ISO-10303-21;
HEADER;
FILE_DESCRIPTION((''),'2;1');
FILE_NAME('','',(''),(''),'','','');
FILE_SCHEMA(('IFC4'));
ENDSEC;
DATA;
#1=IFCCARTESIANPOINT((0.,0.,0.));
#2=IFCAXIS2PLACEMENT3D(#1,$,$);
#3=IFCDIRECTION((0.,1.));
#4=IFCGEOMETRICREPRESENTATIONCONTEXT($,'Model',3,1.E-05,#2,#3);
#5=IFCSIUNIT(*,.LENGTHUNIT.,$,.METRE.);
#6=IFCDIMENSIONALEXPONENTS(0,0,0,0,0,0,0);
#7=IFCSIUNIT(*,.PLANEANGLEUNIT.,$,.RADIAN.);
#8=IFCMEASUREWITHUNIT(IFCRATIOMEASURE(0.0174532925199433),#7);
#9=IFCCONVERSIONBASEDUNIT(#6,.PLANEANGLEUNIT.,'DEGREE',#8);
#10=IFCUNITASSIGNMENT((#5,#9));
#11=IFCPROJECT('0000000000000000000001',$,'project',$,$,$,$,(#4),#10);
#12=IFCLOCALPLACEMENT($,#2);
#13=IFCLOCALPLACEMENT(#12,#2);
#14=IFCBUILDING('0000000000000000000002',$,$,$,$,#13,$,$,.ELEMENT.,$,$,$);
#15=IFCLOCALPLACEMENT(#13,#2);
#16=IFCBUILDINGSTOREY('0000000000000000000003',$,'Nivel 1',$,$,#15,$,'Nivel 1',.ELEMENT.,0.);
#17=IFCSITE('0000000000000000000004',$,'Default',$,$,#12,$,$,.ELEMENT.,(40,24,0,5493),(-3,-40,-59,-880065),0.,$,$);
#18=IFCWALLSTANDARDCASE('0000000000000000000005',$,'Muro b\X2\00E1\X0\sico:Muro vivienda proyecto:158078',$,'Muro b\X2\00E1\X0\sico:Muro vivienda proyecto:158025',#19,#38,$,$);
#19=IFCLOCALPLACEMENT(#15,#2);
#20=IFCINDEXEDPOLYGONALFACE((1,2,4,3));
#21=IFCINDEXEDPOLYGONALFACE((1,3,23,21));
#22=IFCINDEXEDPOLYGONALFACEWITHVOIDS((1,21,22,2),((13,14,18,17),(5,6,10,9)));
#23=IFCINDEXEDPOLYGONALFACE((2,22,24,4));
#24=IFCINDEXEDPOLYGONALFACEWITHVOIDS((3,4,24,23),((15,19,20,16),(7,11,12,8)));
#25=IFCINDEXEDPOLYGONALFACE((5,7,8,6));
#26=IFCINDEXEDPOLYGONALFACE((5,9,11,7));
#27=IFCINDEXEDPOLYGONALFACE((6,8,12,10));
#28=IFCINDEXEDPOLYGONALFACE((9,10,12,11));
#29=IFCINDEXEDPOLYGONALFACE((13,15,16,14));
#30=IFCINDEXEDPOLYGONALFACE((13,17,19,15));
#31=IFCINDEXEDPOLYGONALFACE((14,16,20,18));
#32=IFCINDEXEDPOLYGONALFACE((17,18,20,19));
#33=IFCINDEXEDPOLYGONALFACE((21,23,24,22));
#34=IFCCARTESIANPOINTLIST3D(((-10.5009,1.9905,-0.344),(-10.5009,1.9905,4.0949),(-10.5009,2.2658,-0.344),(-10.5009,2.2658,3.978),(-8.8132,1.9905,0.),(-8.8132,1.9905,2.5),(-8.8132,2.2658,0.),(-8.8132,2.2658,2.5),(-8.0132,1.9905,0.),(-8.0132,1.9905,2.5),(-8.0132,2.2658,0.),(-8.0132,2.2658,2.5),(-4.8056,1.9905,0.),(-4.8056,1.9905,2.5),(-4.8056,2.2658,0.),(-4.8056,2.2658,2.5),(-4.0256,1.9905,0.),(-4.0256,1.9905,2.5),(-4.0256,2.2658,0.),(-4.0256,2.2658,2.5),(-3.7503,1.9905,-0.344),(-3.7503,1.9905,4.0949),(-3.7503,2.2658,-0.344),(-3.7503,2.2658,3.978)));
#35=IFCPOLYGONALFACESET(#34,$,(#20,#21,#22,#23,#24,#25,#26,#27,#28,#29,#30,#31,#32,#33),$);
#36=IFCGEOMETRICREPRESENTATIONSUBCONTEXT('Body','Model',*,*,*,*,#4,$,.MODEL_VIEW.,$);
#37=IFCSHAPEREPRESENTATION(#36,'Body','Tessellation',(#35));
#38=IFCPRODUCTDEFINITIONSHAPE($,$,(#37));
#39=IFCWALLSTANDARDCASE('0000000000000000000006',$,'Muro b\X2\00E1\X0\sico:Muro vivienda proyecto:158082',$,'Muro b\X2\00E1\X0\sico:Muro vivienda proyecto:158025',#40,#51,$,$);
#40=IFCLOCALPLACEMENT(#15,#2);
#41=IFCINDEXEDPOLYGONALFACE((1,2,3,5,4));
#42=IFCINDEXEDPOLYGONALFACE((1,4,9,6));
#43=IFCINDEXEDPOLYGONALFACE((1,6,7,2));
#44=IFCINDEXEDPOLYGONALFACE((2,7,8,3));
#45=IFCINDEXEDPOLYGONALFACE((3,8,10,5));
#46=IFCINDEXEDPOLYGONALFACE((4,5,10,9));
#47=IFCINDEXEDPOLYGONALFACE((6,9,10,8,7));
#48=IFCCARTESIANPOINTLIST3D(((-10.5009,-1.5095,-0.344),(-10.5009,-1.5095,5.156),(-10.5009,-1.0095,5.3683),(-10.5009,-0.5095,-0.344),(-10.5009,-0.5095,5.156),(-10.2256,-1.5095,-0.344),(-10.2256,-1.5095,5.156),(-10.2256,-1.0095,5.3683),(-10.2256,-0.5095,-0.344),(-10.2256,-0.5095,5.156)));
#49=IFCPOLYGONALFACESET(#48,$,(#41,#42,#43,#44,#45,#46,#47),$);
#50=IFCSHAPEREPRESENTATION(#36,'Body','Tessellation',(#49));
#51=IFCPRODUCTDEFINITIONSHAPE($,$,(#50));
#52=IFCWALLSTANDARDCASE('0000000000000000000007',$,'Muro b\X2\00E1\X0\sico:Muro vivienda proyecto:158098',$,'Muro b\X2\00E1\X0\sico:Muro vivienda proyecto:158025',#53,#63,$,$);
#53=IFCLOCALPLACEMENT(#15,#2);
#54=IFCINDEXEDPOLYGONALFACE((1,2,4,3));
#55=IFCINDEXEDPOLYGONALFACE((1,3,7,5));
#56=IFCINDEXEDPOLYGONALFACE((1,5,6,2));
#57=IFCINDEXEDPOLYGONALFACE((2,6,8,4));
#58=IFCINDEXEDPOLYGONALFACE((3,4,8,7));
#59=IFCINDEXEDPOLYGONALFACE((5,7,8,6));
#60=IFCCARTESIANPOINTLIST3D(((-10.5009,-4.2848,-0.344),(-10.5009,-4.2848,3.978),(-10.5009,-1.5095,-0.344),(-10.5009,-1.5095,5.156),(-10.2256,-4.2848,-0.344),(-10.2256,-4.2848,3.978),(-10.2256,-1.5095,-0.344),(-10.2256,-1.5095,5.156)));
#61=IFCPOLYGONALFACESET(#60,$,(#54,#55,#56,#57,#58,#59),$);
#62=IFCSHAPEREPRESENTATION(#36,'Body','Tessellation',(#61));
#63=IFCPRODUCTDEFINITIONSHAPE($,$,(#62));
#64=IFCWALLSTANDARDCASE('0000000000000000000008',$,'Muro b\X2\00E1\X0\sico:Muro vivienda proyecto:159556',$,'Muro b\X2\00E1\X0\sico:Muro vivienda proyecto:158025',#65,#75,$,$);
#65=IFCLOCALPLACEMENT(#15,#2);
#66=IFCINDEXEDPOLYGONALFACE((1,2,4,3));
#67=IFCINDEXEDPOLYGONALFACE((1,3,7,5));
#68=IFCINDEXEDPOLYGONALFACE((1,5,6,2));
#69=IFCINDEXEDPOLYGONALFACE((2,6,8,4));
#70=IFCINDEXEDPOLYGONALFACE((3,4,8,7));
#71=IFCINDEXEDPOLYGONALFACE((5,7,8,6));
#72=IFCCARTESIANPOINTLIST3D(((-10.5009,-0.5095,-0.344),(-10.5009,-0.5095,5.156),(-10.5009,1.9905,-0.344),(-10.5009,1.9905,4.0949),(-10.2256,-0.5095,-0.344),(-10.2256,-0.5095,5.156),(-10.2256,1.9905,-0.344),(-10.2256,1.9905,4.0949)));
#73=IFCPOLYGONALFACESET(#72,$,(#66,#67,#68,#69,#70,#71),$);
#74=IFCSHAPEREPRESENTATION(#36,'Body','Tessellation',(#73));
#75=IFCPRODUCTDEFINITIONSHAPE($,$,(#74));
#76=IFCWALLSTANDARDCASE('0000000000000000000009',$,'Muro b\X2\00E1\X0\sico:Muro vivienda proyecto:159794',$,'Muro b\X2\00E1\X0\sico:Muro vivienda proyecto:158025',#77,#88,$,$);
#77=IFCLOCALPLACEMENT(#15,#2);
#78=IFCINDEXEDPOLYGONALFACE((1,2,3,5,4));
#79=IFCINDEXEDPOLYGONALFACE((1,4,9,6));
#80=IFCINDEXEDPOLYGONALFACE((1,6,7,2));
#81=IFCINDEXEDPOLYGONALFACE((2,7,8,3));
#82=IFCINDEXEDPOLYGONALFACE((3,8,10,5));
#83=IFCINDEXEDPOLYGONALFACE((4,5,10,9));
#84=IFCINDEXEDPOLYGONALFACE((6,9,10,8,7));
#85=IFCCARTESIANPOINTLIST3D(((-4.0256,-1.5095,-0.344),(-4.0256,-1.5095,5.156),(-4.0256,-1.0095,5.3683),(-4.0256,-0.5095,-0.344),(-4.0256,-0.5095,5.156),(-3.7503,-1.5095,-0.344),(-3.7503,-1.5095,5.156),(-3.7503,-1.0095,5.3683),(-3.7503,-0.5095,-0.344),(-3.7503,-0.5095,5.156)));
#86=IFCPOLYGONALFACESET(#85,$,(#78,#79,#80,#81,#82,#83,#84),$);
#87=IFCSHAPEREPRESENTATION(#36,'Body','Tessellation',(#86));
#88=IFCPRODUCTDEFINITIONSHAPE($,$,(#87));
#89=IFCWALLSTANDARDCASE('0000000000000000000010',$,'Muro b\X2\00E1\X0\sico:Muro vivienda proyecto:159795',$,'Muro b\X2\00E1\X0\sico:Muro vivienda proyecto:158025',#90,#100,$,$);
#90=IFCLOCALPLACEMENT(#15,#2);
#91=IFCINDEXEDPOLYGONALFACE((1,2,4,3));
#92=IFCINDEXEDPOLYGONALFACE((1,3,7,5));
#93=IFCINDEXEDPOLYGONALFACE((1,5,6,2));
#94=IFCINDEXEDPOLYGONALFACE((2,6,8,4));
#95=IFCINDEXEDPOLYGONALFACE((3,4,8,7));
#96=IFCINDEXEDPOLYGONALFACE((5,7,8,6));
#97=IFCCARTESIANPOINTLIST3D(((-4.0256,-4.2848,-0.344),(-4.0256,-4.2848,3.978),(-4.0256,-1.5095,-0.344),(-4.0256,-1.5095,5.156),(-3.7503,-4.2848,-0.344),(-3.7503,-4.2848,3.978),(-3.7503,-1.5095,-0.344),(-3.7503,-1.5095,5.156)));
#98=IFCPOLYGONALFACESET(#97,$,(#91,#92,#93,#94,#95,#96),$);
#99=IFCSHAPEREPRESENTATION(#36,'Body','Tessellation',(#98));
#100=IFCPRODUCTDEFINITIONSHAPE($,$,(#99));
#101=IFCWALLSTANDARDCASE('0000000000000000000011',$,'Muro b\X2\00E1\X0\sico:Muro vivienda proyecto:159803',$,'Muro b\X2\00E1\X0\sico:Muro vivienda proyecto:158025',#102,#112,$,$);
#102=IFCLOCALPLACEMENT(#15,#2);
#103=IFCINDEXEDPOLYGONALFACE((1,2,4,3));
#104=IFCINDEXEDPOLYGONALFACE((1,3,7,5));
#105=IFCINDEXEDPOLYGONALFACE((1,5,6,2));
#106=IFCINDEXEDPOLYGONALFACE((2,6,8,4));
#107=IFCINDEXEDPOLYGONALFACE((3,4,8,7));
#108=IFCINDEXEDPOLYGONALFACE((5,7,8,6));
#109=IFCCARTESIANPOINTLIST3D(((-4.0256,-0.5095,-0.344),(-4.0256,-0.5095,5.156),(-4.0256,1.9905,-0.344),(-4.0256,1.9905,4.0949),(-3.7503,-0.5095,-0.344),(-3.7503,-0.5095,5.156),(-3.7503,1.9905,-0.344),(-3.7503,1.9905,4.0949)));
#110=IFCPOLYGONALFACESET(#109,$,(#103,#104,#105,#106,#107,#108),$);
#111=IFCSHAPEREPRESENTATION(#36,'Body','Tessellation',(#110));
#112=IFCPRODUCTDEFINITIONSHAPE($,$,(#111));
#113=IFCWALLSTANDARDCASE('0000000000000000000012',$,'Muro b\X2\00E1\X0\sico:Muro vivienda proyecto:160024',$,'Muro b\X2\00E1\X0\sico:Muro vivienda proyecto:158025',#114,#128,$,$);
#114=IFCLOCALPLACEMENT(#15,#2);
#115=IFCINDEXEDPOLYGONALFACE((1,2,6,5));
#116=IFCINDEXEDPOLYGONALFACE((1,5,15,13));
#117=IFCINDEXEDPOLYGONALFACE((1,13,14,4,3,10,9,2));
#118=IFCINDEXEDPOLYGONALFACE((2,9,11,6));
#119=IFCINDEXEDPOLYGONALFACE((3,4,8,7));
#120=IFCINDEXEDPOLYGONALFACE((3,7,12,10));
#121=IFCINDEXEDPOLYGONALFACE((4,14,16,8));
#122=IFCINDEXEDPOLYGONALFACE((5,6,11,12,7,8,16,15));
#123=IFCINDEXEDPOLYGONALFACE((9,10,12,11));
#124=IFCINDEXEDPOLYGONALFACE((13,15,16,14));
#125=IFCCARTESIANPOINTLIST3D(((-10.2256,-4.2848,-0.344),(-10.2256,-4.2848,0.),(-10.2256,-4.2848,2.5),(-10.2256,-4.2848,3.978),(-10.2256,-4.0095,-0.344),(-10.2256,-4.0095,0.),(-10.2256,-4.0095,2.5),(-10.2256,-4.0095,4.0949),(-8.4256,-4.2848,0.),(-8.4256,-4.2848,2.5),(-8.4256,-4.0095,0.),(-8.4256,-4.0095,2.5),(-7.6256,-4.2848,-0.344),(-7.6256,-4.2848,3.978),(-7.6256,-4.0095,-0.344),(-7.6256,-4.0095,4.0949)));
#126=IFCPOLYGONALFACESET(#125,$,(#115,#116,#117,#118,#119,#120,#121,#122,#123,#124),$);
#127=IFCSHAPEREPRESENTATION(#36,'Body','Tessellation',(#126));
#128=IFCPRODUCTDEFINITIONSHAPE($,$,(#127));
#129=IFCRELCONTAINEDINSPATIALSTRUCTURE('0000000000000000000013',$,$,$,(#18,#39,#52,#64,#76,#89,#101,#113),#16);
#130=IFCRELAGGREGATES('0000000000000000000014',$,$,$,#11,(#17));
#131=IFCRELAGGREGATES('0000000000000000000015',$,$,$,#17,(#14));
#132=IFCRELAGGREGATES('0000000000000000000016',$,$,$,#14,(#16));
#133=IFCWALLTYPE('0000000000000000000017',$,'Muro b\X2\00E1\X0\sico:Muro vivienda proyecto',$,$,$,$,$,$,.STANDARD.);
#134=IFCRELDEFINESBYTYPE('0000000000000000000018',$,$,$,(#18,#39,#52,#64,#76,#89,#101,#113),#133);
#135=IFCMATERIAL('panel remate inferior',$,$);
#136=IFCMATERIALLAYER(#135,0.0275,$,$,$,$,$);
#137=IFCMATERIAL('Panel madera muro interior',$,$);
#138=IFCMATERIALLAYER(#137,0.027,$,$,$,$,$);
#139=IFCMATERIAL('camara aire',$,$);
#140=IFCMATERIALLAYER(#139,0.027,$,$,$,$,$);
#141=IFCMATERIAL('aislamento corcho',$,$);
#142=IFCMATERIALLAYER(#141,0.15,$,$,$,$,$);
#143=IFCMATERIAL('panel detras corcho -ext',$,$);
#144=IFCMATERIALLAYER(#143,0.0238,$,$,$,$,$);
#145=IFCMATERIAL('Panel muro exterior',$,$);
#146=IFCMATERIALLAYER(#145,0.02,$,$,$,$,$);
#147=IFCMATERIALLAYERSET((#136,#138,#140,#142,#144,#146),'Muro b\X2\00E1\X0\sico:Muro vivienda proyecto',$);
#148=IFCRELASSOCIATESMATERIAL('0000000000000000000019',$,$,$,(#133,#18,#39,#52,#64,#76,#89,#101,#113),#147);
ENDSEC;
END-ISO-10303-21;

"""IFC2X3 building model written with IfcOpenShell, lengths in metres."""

from ifc_helpers import new_model, entity, si_unit, converted_unit, direction, frame, frame_2d, origin, place, context, subcontext, project, spatial, polyline, rectangle, extrude, clip, bounded_halfspace, material, layer, layer_set, layer_usage, type_object, element, save


model = new_model("IFC2X3")

# Units and contexts
model_context = context("Model", 3, precision=1e-05, world=origin(), true_north=direction((0.0, 1.0)))
body_context = subcontext(model_context, "Body", "Model", "MODEL_VIEW")
ifc_project = project(units=[si_unit("LENGTHUNIT", "METRE"), converted_unit("PLANEANGLEUNIT", "DEGREE", entity("IfcRatioMeasure", 0.0174532925199433), si_unit("PLANEANGLEUNIT", "RADIAN"), dimensions=[0, 0, 0, 0, 0, 0, 0])], contexts=[model_context])

# Site, building, storey
site_placement = place(None, origin())
site = spatial("IfcSite", under=ifc_project, at=site_placement, Name="Default", CompositionType="ELEMENT", RefLatitude=(40, 24, 0, 5493), RefLongitude=(-3, -40, -59, -880065), RefElevation=0.0)
building_placement = place(site_placement, origin())
building = spatial("IfcBuilding", under=site, at=building_placement, CompositionType="ELEMENT")
storey_placement = place(building_placement, origin())
storey = spatial("IfcBuildingStorey", under=building, at=storey_placement, Name="Nivel 1", LongName="Nivel 1", CompositionType="ELEMENT", Elevation=0.0)

# Shared definitions
ifc_material_1 = material(Name="aislamento corcho")
ifc_material_2 = material(Name="camara aire")
ifc_material_3 = material(Name="panel remate inferior")

# Shared definitions
ifc_layer_1 = layer(ifc_material_3, 0.0275)
ifc_material_4 = material(Name="Panel madera muro interior")
ifc_layer_2 = layer(ifc_material_4, 0.027)
ifc_layer_3 = layer(ifc_material_2, 0.027)
ifc_layer_4 = layer(ifc_material_1, 0.15)
ifc_material_5 = material(Name="panel detras corcho -ext")
ifc_layer_5 = layer(ifc_material_5, 0.0238)
ifc_material_6 = material(Name="Panel muro exterior")
ifc_layer_6 = layer(ifc_material_6, 0.02)
ifc_layer_set_1 = layer_set([ifc_layer_1, ifc_layer_2, ifc_layer_3, ifc_layer_4, ifc_layer_5, ifc_layer_6], Name="Muro básico:Muro vivienda proyecto")
wall_type = type_object("IfcWallType", Name="Muro básico:Muro vivienda proyecto", PredefinedType="STANDARD", material=ifc_layer_set_1)

# Wall, openings
ifc_layer_usage_1 = layer_usage(ifc_layer_set_1, "AXIS2", "NEGATIVE", 0.1376)
wall_1_placement = place(storey_placement, frame((-10.5009, 2.1282, -0.344)))
wall_1 = element("IfcWallStandardCase", 1, at=wall_1_placement, inside=storey, type_object=wall_type, material=ifc_layer_usage_1, Name="Muro básico:Muro vivienda proyecto:158078", ObjectType="Muro básico:Muro vivienda proyecto:158025", context=body_context, shape_type="Clipping", body=[
    clip(extrude(rectangle(XDim=6.7506, YDim=0.2753, at=frame_2d((3.3753, 0.0), x_axis=(-1.0, 0.0))), origin(), (0.0, 0.0, 1.0), 4.4389), bounded_halfspace(frame((0.0, -0.1376, 4.4389), z_axis=(0.0, 0.390731, 0.920505), x_axis=(-1.0, 0.0, 0.0)), False, frame((0.0, -0.1376, 4.4389)), polyline([(0.0, 0.0), (0.2753, 0.0), (6.4753, 0.0), (6.7506, 0.0), (6.7506, 0.2753), (0.0, 0.2753), (0.0, 0.0)]))),
])
opening_1_placement = place(wall_1_placement, origin())
element("IfcOpeningElement", 2, at=opening_1_placement, cuts=wall_1, ObjectType="Opening", context=body_context, shape_type="SweptSolid", body=[
    extrude(rectangle(XDim=2.5, YDim=0.8, at=frame_2d((0.0, 0.0), x_axis=(0.0, 1.0))), frame((2.0876, -0.29, 1.594), z_axis=(0.0, 1.0, 0.0), x_axis=(-1.0, 0.0, 0.0)), (0.0, 0.0, 1.0), 0.5801),
])
opening_2_placement = place(wall_1_placement, origin())
element("IfcOpeningElement", 3, at=opening_2_placement, cuts=wall_1, ObjectType="Opening", context=body_context, shape_type="SweptSolid", body=[
    extrude(rectangle(XDim=2.5, YDim=0.78, at=frame_2d((0.0, 0.0), x_axis=(0.0, 1.0))), frame((6.0853, -0.29, 1.594), z_axis=(0.0, 1.0, 0.0), x_axis=(-1.0, 0.0, 0.0)), (0.0, 0.0, 1.0), 0.5801),
])

# Walls
ifc_layer_usage_2 = layer_usage(ifc_layer_set_1, "AXIS2", "NEGATIVE", 0.1376)
wall_2_placement = place(storey_placement, frame((-10.3632, -1.5095, -0.344), z_axis=(0.0, 0.0, 1.0), x_axis=(0.0, 1.0, 0.0)))
element("IfcWallStandardCase", 4, at=wall_2_placement, inside=storey, type_object=wall_type, material=ifc_layer_usage_2, Name="Muro básico:Muro vivienda proyecto:158082", ObjectType="Muro básico:Muro vivienda proyecto:158025", context=body_context, shape_type="Clipping", body=[
    clip(clip(extrude(rectangle(XDim=1.0, YDim=0.2753, at=frame_2d((0.5, 0.0), x_axis=(-1.0, 0.0))), origin(), (0.0, 0.0, 1.0), 5.7123), bounded_halfspace(frame((0.5, -0.1377, 5.7123), z_axis=(0.390731, 0.0, 0.920505), x_axis=(0.0, 1.0, 0.0)), False, frame((0.5, -0.1377, 5.7123)), polyline([(0.0, 0.0), (0.5, 0.0), (0.5, 0.2753), (0.0, 0.2753), (0.0, 0.0)]))), bounded_halfspace(frame((0.0, -0.1377, 5.5), z_axis=(-0.390731, 0.0, 0.920505), x_axis=(0.0, -1.0, 0.0)), False, frame((0.0, -0.1377, 5.5)), polyline([(0.0, 0.0), (0.5, 0.0), (0.5, 0.2753), (0.0, 0.2753), (0.0, 0.0)]))),
])
ifc_layer_usage_3 = layer_usage(ifc_layer_set_1, "AXIS2", "NEGATIVE", 0.1376)
wall_3_placement = place(storey_placement, frame((-10.3632, -4.2848, -0.344), z_axis=(0.0, 0.0, 1.0), x_axis=(0.0, 1.0, 0.0)))
element("IfcWallStandardCase", 5, at=wall_3_placement, inside=storey, type_object=wall_type, material=ifc_layer_usage_3, Name="Muro básico:Muro vivienda proyecto:158098", ObjectType="Muro básico:Muro vivienda proyecto:158025", context=body_context, shape_type="Clipping", body=[
    clip(extrude(rectangle(XDim=2.7753, YDim=0.2753, at=frame_2d((1.3877, 0.0), x_axis=(-1.0, 0.0))), origin(), (0.0, 0.0, 1.0), 5.5), bounded_halfspace(frame((0.0, -0.1377, 4.322), z_axis=(-0.390731, 0.0, 0.920505), x_axis=(0.0, -1.0, 0.0)), False, frame((0.0, -0.1377, 4.322)), polyline([(0.0, 0.0), (0.2753, 0.0), (2.7753, 0.0), (2.7753, 0.2753), (0.0, 0.2753), (0.0, 0.0)]))),
])
ifc_layer_usage_4 = layer_usage(ifc_layer_set_1, "AXIS2", "POSITIVE", -0.1376)
wall_4_placement = place(storey_placement, frame((-10.3632, 1.9905, -0.344), z_axis=(0.0, 0.0, 1.0), x_axis=(0.0, -1.0, 0.0)))
element("IfcWallStandardCase", 6, at=wall_4_placement, inside=storey, type_object=wall_type, material=ifc_layer_usage_4, Name="Muro básico:Muro vivienda proyecto:159556", ObjectType="Muro básico:Muro vivienda proyecto:158025", context=body_context, shape_type="Clipping", body=[
    clip(extrude(rectangle(XDim=2.5, YDim=0.2753, at=frame_2d((1.25, 0.0), x_axis=(-1.0, 0.0))), origin(), (0.0, 0.0, 1.0), 5.5), bounded_halfspace(frame((0.0, -0.1377, 4.4389), z_axis=(-0.390731, 0.0, 0.920505), x_axis=(0.0, -1.0, 0.0)), False, frame((0.0, -0.1377, 4.4389)), polyline([(0.0, 0.0), (2.5, 0.0), (2.5, 0.2753), (0.0, 0.2753), (0.0, 0.0)]))),
])
ifc_layer_usage_5 = layer_usage(ifc_layer_set_1, "AXIS2", "POSITIVE", -0.1376)
wall_5_placement = place(storey_placement, frame((-3.8879, -1.5095, -0.344), z_axis=(0.0, 0.0, 1.0), x_axis=(0.0, 1.0, 0.0)))
element("IfcWallStandardCase", 7, at=wall_5_placement, inside=storey, type_object=wall_type, material=ifc_layer_usage_5, Name="Muro básico:Muro vivienda proyecto:159794", ObjectType="Muro básico:Muro vivienda proyecto:158025", context=body_context, shape_type="Clipping", body=[
    clip(clip(extrude(rectangle(XDim=1.0, YDim=0.2753, at=frame_2d((0.5, 0.0), x_axis=(-1.0, 0.0))), origin(), (0.0, 0.0, 1.0), 5.7123), bounded_halfspace(frame((0.5, -0.1376, 5.7123), z_axis=(0.390731, 0.0, 0.920505), x_axis=(0.0, 1.0, 0.0)), False, frame((0.5, -0.1376, 5.7123)), polyline([(0.0, 0.0), (0.5, 0.0), (0.5, 0.2753), (0.0, 0.2753), (0.0, 0.0)]))), bounded_halfspace(frame((0.0, -0.1376, 5.5), z_axis=(-0.390731, 0.0, 0.920505), x_axis=(0.0, -1.0, 0.0)), False, frame((0.0, -0.1376, 5.5)), polyline([(0.0, 0.0), (0.5, 0.0), (0.5, 0.2753), (0.0, 0.2753), (0.0, 0.0)]))),
])
ifc_layer_usage_6 = layer_usage(ifc_layer_set_1, "AXIS2", "POSITIVE", -0.1376)
wall_6_placement = place(storey_placement, frame((-3.8879, -4.2848, -0.344), z_axis=(0.0, 0.0, 1.0), x_axis=(0.0, 1.0, 0.0)))
element("IfcWallStandardCase", 8, at=wall_6_placement, inside=storey, type_object=wall_type, material=ifc_layer_usage_6, Name="Muro básico:Muro vivienda proyecto:159795", ObjectType="Muro básico:Muro vivienda proyecto:158025", context=body_context, shape_type="Clipping", body=[
    clip(extrude(rectangle(XDim=2.7753, YDim=0.2753, at=frame_2d((1.3877, 0.0), x_axis=(-1.0, 0.0))), origin(), (0.0, 0.0, 1.0), 5.5), bounded_halfspace(frame((0.0, -0.1376, 4.322), z_axis=(-0.390731, 0.0, 0.920505), x_axis=(0.0, -1.0, 0.0)), False, frame((0.0, -0.1376, 4.322)), polyline([(0.0, 0.0), (2.7753, 0.0), (2.7753, 0.2753), (0.2753, 0.2753), (0.0, 0.2753), (0.0, 0.0)]))),
])
ifc_layer_usage_7 = layer_usage(ifc_layer_set_1, "AXIS2", "NEGATIVE", 0.1376)
wall_7_placement = place(storey_placement, frame((-3.8879, 1.9905, -0.344), z_axis=(0.0, 0.0, 1.0), x_axis=(0.0, -1.0, 0.0)))
element("IfcWallStandardCase", 9, at=wall_7_placement, inside=storey, type_object=wall_type, material=ifc_layer_usage_7, Name="Muro básico:Muro vivienda proyecto:159803", ObjectType="Muro básico:Muro vivienda proyecto:158025", context=body_context, shape_type="Clipping", body=[
    clip(extrude(rectangle(XDim=2.5, YDim=0.2753, at=frame_2d((1.25, 0.0), x_axis=(-1.0, 0.0))), origin(), (0.0, 0.0, 1.0), 5.5), bounded_halfspace(frame((0.0, -0.1376, 4.4389), z_axis=(-0.390731, 0.0, 0.920505), x_axis=(0.0, -1.0, 0.0)), False, frame((0.0, -0.1376, 4.4389)), polyline([(0.0, 0.0), (2.5, 0.0), (2.5, 0.2753), (0.0, 0.2753), (0.0, 0.0)]))),
])

# Wall, opening
ifc_layer_usage_8 = layer_usage(ifc_layer_set_1, "AXIS2", "POSITIVE", -0.1376)
wall_8_placement = place(storey_placement, frame((-10.2256, -4.1471, -0.344)))
wall_8 = element("IfcWallStandardCase", 10, at=wall_8_placement, inside=storey, type_object=wall_type, material=ifc_layer_usage_8, Name="Muro básico:Muro vivienda proyecto:160024", ObjectType="Muro básico:Muro vivienda proyecto:158025", context=body_context, shape_type="Clipping", body=[
    clip(extrude(rectangle(XDim=2.6, YDim=0.2753, at=frame_2d((1.3, 0.0), x_axis=(-1.0, 0.0))), origin(), (0.0, 0.0, 1.0), 4.4389), bounded_halfspace(frame((0.0, -0.1376, 4.322), z_axis=(0.0, -0.390731, 0.920505), x_axis=(1.0, 0.0, 0.0)), False, frame((0.0, -0.1376, 4.322)), polyline([(0.0, 0.0), (2.6, 0.0), (2.6, 0.2753), (0.0, 0.2753), (0.0, 0.0)]))),
])
opening_3_placement = place(wall_8_placement, origin())
element("IfcOpeningElement", 11, at=opening_3_placement, cuts=wall_8, ObjectType="Opening", context=body_context, shape_type="SweptSolid", body=[
    extrude(rectangle(XDim=2.5, YDim=1.8, at=frame_2d((0.0, 0.0), x_axis=(1.0, 0.0))), frame((0.9, -0.29, 1.594), z_axis=(0.0, 1.0, 0.0), x_axis=(0.0, 0.0, 1.0)), (0.0, 0.0, 1.0), 0.5801),
])

save(model, "model.ifc")
